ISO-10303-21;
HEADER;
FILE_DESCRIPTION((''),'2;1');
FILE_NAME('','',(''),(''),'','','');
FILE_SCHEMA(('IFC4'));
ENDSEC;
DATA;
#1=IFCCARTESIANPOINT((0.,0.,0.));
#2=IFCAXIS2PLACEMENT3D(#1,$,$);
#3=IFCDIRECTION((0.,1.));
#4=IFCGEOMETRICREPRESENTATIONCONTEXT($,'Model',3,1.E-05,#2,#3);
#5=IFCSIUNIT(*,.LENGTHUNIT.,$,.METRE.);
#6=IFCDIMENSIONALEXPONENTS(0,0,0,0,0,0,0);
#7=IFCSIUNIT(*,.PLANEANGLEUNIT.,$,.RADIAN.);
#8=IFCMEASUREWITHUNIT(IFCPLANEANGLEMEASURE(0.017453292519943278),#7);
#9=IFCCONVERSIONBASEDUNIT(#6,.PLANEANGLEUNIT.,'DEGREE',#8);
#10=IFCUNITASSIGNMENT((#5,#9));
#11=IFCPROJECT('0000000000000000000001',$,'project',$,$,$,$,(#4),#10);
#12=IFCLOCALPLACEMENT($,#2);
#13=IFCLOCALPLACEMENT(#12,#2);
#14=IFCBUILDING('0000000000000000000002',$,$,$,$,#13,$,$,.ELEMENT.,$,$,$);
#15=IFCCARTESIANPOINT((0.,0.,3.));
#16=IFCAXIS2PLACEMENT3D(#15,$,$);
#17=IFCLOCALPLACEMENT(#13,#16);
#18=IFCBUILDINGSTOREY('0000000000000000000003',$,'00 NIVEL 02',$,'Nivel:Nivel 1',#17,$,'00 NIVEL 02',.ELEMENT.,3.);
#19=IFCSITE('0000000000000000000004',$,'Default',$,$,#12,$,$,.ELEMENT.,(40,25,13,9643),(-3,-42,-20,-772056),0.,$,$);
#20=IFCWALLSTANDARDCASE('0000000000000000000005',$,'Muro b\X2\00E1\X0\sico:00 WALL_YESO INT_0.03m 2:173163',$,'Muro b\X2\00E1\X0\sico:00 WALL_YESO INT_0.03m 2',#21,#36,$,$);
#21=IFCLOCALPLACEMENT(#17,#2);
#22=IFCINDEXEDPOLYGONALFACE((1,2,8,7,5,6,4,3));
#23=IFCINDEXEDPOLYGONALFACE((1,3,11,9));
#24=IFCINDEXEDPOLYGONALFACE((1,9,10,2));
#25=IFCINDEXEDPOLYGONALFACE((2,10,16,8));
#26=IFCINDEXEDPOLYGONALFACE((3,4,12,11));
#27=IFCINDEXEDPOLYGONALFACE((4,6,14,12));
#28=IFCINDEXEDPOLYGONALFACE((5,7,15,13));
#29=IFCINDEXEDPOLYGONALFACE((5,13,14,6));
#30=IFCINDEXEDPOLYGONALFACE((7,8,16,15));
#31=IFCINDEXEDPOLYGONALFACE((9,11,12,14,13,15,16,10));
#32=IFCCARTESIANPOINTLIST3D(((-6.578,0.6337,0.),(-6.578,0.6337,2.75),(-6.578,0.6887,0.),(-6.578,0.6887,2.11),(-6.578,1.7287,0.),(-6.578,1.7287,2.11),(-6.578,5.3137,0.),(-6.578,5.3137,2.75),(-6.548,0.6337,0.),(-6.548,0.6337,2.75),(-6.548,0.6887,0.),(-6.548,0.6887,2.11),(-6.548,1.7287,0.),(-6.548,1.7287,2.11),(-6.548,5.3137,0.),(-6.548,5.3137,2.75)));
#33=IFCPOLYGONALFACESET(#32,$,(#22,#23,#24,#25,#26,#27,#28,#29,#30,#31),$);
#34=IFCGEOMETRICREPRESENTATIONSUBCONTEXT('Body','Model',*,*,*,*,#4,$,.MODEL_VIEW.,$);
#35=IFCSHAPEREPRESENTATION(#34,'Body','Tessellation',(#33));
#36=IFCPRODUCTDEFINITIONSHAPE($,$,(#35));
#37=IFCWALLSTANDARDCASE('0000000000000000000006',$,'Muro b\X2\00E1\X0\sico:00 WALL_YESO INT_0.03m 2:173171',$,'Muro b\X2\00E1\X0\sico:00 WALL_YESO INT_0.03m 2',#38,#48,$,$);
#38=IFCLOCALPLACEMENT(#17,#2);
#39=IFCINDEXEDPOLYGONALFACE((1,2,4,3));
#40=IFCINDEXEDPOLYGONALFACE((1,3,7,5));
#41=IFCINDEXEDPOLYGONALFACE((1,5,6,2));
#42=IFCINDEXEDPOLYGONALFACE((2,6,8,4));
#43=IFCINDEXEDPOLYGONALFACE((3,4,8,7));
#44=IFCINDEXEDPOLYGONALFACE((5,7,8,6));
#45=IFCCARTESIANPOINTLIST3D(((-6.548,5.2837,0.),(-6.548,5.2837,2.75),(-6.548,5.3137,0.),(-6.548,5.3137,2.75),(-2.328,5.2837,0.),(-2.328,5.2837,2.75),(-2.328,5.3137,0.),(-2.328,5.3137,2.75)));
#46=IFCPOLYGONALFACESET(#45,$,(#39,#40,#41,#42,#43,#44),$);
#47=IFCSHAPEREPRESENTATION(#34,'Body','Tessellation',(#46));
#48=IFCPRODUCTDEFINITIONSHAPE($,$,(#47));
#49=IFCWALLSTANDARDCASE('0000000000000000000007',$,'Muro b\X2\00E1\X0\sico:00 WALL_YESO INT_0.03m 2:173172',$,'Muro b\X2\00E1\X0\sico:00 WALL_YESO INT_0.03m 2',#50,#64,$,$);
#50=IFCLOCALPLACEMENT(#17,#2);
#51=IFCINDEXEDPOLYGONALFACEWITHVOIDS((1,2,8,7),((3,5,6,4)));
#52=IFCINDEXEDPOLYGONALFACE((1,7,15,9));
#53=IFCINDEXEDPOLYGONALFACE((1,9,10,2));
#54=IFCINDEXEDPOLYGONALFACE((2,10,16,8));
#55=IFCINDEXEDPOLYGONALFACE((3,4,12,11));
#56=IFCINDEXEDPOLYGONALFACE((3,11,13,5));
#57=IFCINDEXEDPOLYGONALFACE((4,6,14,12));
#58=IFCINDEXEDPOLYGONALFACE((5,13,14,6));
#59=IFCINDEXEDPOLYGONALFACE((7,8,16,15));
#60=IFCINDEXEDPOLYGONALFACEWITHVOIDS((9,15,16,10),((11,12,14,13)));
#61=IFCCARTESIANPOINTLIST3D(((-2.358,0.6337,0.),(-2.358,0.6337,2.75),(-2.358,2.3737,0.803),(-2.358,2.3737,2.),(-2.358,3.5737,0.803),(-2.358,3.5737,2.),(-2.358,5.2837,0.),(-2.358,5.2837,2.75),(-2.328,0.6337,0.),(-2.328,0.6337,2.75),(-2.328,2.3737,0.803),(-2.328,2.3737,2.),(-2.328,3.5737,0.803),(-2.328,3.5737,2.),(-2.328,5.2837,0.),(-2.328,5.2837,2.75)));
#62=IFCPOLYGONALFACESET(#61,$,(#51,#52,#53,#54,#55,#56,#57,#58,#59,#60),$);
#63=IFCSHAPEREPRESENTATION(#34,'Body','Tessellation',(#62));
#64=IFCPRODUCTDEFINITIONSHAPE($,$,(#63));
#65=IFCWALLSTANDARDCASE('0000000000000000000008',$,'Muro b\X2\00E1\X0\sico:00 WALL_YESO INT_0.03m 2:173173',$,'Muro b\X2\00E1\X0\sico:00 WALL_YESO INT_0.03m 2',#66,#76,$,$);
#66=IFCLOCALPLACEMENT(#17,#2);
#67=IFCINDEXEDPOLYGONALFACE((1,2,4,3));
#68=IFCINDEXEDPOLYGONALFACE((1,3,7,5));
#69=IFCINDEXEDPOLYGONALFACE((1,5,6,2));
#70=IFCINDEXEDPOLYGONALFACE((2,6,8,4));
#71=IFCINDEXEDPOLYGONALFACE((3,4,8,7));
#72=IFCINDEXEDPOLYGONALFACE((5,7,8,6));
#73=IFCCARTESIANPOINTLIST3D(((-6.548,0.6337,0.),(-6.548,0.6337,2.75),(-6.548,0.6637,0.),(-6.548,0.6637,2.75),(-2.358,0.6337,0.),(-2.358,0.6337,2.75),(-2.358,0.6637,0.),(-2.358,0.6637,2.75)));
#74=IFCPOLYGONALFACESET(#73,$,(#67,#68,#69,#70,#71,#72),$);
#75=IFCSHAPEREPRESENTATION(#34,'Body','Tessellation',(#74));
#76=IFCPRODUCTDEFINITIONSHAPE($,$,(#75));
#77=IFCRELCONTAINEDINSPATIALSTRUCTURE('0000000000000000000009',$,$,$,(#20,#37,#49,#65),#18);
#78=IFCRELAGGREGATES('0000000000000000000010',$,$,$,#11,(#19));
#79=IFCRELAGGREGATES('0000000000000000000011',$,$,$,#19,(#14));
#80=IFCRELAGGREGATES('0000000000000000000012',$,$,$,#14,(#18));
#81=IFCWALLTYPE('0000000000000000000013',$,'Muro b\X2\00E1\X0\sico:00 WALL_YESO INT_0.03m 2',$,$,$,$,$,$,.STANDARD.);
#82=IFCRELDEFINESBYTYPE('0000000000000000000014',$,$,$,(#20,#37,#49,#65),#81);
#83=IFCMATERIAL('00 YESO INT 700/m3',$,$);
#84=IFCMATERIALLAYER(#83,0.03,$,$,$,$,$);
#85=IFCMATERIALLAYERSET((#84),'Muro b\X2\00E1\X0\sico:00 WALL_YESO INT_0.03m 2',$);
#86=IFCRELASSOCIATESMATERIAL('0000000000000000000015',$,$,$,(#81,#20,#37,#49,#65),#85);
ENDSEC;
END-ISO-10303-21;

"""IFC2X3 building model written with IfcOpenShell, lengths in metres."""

from ifc_helpers import new_model, entity, si_unit, converted_unit, direction, frame, frame_2d, origin, place, context, subcontext, project, spatial, rectangle, extrude, material, layer, layer_set, layer_usage, type_object, element, save


model = new_model("IFC2X3")

# Units and contexts
model_context = context("Model", 3, precision=1e-05, world=origin(), true_north=direction((0.0, 1.0)))
body_context = subcontext(model_context, "Body", "Model", "MODEL_VIEW")
ifc_project = project(units=[si_unit("LENGTHUNIT", "METRE"), converted_unit("PLANEANGLEUNIT", "DEGREE", entity("IfcPlaneAngleMeasure", 0.017453292519943278), si_unit("PLANEANGLEUNIT", "RADIAN"), dimensions=[0, 0, 0, 0, 0, 0, 0])], contexts=[model_context])

# Site, building, storey
site_placement = place(None, origin())
site = spatial("IfcSite", under=ifc_project, at=site_placement, Name="Default", CompositionType="ELEMENT", RefLatitude=(40, 25, 13, 9643), RefLongitude=(-3, -42, -20, -772056), RefElevation=0.0)
building_placement = place(site_placement, origin())
building = spatial("IfcBuilding", under=site, at=building_placement, CompositionType="ELEMENT")
storey_placement = place(building_placement, frame((0.0, 0.0, 3.0)))
storey = spatial("IfcBuildingStorey", under=building, at=storey_placement, Name="00 NIVEL 02", ObjectType="Nivel:Nivel 1", LongName="00 NIVEL 02", CompositionType="ELEMENT", Elevation=3.0)

# Wall, opening
ifc_material_1 = material(Name="00 YESO INT 700/m3")
ifc_layer_1 = layer(ifc_material_1, 0.03)
ifc_layer_set_1 = layer_set([ifc_layer_1], Name="Muro básico:00 WALL_YESO INT_0.03m 2")
ifc_layer_usage_1 = layer_usage(ifc_layer_set_1, "AXIS2", "POSITIVE", -0.015)
wall_type_1 = type_object("IfcWallType", Name="Muro básico:00 WALL_YESO INT_0.03m 2", PredefinedType="STANDARD", material=ifc_layer_set_1)
wall_1_placement = place(storey_placement, frame((-6.563, 5.3137, 0.0), z_axis=(0.0, 0.0, 1.0), x_axis=(0.0, -1.0, 0.0)))
wall_1 = element("IfcWallStandardCase", 1, at=wall_1_placement, inside=storey, type_object=wall_type_1, material=ifc_layer_usage_1, Name="Muro básico:00 WALL_YESO INT_0.03m 2:173163", ObjectType="Muro básico:00 WALL_YESO INT_0.03m 2", context=body_context, shape_type="SweptSolid", body=[
    extrude(rectangle(XDim=4.68, YDim=0.03, at=frame_2d((2.34, 0.0), x_axis=(-1.0, 0.0))), origin(), (0.0, 0.0, 1.0), 2.75),
])
opening_1_placement = place(wall_1_placement, origin())
element("IfcOpeningElement", 2, at=opening_1_placement, cuts=wall_1, ObjectType="Opening", context=body_context, shape_type="SweptSolid", body=[
    extrude(rectangle(XDim=2.11, YDim=1.04, at=frame_2d((0.0, 0.0), x_axis=(0.0, 1.0))), frame((4.105, 0.015, 1.055), z_axis=(0.0, -1.0, 0.0), x_axis=(1.0, 0.0, 0.0)), (0.0, 0.0, 1.0), 0.03),
])

# Wall
ifc_layer_usage_2 = layer_usage(ifc_layer_set_1, "AXIS2", "NEGATIVE", 0.015)
wall_2_placement = place(storey_placement, frame((-6.548, 5.2987, 0.0)))
element("IfcWallStandardCase", 3, at=wall_2_placement, inside=storey, type_object=wall_type_1, material=ifc_layer_usage_2, Name="Muro básico:00 WALL_YESO INT_0.03m 2:173171", ObjectType="Muro básico:00 WALL_YESO INT_0.03m 2", context=body_context, shape_type="SweptSolid", body=[
    extrude(rectangle(XDim=4.22, YDim=0.03, at=frame_2d((2.11, 0.0), x_axis=(-1.0, 0.0))), origin(), (0.0, 0.0, 1.0), 2.75),
])

# Wall, opening
ifc_layer_usage_3 = layer_usage(ifc_layer_set_1, "AXIS2", "NEGATIVE", 0.015)
wall_3_placement = place(storey_placement, frame((-2.343, 5.2837, 0.0), z_axis=(0.0, 0.0, 1.0), x_axis=(0.0, -1.0, 0.0)))
wall_3 = element("IfcWallStandardCase", 4, at=wall_3_placement, inside=storey, type_object=wall_type_1, material=ifc_layer_usage_3, Name="Muro básico:00 WALL_YESO INT_0.03m 2:173172", ObjectType="Muro básico:00 WALL_YESO INT_0.03m 2", context=body_context, shape_type="SweptSolid", body=[
    extrude(rectangle(XDim=4.65, YDim=0.03, at=frame_2d((2.325, 0.0), x_axis=(-1.0, 0.0))), origin(), (0.0, 0.0, 1.0), 2.75),
])
opening_2_placement = place(wall_3_placement, origin())
element("IfcOpeningElement", 5, at=opening_2_placement, cuts=wall_3, ObjectType="Opening", context=body_context, shape_type="SweptSolid", body=[
    extrude(rectangle(XDim=1.197, YDim=1.2, at=frame_2d((0.0, 0.0), x_axis=(0.0, 1.0))), frame((2.31, 0.015, 1.4015), z_axis=(0.0, -1.0, 0.0), x_axis=(1.0, 0.0, 0.0)), (0.0, 0.0, 1.0), 0.03),
])

# Wall
ifc_layer_usage_4 = layer_usage(ifc_layer_set_1, "AXIS2", "NEGATIVE", 0.015)
wall_4_placement = place(storey_placement, frame((-2.358, 0.6487, 0.0), z_axis=(0.0, 0.0, 1.0), x_axis=(-1.0, 0.0, 0.0)))
element("IfcWallStandardCase", 6, at=wall_4_placement, inside=storey, type_object=wall_type_1, material=ifc_layer_usage_4, Name="Muro básico:00 WALL_YESO INT_0.03m 2:173173", ObjectType="Muro básico:00 WALL_YESO INT_0.03m 2", context=body_context, shape_type="SweptSolid", body=[
    extrude(rectangle(XDim=4.19, YDim=0.03, at=frame_2d((2.095, 0.0), x_axis=(-1.0, 0.0))), origin(), (0.0, 0.0, 1.0), 2.75),
])

save(model, "model.ifc")
